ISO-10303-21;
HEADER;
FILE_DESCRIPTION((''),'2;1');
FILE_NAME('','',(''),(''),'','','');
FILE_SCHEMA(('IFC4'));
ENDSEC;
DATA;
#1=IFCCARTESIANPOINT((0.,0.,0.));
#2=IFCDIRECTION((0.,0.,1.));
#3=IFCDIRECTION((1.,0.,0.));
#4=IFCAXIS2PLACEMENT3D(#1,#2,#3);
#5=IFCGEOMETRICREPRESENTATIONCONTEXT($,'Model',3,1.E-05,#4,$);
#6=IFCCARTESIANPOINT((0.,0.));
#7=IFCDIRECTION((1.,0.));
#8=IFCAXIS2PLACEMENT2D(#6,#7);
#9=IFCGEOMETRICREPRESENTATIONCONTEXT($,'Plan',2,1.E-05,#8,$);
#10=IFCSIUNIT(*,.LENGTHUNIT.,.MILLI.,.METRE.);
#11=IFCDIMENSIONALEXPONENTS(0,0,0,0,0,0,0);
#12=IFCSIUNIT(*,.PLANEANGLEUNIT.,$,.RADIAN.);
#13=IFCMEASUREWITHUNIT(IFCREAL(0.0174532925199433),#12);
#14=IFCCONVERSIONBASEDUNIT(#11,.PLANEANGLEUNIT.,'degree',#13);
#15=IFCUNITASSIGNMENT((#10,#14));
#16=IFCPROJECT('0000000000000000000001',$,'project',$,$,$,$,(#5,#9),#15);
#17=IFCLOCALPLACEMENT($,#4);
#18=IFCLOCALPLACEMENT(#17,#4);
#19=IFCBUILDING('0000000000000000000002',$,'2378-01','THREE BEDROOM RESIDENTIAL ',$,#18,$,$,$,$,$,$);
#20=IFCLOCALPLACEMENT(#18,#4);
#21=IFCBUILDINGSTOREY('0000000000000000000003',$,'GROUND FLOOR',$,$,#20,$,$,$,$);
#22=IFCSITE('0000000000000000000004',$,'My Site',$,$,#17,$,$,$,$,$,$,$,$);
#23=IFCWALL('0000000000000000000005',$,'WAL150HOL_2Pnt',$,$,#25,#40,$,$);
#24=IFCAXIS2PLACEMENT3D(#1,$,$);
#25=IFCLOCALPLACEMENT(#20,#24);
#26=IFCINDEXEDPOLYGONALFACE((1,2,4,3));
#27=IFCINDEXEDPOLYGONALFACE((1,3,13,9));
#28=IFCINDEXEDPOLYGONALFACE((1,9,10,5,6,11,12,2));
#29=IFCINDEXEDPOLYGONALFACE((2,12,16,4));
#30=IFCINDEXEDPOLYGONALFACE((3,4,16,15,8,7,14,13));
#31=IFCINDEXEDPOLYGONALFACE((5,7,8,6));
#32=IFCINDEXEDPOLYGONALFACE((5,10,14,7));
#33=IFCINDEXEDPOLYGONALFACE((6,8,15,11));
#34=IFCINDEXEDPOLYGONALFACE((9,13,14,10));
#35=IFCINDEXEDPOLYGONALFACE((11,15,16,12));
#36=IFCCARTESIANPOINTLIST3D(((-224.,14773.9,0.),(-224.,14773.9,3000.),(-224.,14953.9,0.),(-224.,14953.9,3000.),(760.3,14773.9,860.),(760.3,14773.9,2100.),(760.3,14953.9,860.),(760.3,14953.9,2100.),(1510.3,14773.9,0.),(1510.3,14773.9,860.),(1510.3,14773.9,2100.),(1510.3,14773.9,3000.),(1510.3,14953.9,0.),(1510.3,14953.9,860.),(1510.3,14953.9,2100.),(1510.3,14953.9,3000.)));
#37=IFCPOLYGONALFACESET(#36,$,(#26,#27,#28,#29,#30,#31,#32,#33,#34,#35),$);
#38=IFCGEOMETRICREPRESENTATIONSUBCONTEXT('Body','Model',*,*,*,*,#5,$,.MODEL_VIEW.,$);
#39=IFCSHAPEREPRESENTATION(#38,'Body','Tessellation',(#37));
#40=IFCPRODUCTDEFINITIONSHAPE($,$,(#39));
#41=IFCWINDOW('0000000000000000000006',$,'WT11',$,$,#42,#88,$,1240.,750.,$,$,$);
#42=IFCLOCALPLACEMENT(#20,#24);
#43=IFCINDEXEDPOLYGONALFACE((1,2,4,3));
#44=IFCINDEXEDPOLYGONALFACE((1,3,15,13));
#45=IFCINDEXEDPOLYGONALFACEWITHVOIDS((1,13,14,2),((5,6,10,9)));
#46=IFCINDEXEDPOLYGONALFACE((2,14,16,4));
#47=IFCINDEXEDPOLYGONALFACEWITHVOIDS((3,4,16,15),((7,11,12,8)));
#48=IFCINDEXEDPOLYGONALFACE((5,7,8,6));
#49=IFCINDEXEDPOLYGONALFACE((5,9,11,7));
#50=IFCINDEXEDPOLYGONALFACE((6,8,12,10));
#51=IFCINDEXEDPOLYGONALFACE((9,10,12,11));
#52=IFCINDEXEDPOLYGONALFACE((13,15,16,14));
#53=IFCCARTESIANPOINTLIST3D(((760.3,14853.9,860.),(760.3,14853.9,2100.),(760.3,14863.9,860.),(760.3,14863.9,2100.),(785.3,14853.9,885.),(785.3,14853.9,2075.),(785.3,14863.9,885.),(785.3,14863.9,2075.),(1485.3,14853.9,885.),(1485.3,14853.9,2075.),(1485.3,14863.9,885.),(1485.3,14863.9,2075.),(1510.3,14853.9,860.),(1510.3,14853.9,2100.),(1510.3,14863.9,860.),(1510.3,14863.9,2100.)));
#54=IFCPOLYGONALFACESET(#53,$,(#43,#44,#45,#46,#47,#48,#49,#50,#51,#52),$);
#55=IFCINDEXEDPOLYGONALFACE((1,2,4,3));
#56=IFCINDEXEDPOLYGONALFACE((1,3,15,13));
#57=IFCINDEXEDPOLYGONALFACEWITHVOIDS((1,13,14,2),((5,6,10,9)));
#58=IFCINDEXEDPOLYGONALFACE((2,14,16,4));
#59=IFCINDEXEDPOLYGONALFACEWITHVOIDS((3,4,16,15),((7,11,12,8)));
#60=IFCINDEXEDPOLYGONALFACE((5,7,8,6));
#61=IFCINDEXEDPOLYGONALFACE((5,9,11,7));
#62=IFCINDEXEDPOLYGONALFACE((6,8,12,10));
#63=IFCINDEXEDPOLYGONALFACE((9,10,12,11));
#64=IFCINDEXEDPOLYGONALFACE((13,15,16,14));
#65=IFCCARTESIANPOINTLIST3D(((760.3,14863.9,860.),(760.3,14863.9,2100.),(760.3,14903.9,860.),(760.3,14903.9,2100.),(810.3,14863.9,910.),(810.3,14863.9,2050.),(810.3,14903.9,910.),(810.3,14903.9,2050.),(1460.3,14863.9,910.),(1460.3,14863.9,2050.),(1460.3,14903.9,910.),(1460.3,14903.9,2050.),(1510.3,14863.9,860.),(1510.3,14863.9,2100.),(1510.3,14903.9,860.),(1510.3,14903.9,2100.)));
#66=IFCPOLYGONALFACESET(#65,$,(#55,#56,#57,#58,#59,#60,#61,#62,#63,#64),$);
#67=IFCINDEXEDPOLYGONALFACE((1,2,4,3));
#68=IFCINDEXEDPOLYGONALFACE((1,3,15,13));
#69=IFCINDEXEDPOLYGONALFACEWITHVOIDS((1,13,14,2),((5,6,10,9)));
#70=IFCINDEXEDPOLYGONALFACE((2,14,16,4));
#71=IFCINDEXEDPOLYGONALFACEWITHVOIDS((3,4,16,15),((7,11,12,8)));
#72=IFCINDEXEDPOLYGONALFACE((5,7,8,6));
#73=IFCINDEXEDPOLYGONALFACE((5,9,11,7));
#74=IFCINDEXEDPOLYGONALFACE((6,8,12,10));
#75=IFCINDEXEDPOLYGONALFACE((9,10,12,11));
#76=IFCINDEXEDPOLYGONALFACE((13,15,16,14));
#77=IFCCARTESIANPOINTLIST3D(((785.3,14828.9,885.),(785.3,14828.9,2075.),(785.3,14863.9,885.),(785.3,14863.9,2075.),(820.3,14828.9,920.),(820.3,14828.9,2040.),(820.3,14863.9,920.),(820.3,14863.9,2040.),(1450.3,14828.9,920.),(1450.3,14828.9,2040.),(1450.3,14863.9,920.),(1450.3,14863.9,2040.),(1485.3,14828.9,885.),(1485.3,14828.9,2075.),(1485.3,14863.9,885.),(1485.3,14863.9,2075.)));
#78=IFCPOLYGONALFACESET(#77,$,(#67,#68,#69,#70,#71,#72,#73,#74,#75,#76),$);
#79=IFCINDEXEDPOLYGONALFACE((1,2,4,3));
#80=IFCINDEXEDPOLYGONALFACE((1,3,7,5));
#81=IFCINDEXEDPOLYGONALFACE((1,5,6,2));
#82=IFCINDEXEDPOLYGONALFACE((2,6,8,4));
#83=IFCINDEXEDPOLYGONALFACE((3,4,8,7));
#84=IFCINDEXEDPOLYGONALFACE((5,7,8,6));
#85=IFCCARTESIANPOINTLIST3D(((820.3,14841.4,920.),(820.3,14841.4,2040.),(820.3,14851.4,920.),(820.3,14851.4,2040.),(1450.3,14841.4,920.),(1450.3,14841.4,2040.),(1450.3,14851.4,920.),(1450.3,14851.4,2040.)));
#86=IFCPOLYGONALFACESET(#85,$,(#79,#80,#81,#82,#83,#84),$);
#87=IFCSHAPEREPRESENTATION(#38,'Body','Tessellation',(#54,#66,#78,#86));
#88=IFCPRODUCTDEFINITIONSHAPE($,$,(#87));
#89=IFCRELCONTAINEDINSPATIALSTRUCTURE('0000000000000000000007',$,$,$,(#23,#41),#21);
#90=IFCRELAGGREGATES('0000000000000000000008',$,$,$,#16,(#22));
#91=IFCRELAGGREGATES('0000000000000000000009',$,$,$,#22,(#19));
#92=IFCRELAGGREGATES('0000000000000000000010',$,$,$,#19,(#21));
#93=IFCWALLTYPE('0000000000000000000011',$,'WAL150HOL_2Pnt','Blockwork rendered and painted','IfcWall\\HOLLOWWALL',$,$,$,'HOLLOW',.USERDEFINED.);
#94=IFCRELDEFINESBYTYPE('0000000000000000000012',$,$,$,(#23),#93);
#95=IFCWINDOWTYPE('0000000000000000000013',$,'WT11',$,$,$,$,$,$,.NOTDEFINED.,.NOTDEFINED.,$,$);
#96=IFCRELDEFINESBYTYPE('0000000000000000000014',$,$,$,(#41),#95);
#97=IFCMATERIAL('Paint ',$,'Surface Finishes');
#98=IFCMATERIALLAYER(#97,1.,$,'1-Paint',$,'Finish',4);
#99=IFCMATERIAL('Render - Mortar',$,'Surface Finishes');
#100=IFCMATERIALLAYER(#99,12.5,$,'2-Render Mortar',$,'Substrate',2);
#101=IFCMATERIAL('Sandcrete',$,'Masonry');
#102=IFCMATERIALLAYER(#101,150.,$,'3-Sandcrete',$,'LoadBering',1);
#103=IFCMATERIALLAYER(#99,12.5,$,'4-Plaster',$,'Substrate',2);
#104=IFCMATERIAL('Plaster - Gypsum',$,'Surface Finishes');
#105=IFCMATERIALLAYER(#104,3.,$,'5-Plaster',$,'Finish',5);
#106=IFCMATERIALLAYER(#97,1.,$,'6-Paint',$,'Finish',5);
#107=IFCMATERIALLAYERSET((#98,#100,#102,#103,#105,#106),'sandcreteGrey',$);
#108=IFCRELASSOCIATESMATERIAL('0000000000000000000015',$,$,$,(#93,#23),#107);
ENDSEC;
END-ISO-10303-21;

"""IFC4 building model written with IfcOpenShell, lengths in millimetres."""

from ifc_helpers import new_model, entity, si_unit, converted_unit, frame, origin_with_axes, origin_2d_with_axis, place, context, subcontext, project, spatial, line, indexed_curve, outline, extrude, shape, source, transform, mapped, material, layer, layer_set, layer_usage, type_object, type_shapes, element, fill, save


model = new_model("IFC4")

# Units and contexts
model_context = context("Model", 3, precision=1e-05, world=origin_with_axes())
plan_context = context("Plan", 2, precision=1e-05, world=origin_2d_with_axis())
body_context_1 = subcontext(model_context, "Body", "Model", "MODEL_VIEW")
body_context_2 = subcontext(plan_context, "Body", "Plan", "PLAN_VIEW")
ifc_project = project(units=[si_unit("LENGTHUNIT", "METRE", prefix="MILLI"), converted_unit("PLANEANGLEUNIT", "degree", entity("IfcReal", 0.0174532925199433), si_unit("PLANEANGLEUNIT", "RADIAN"), dimensions=[0, 0, 0, 0, 0, 0, 0])], contexts=[model_context, plan_context])

# Site, building, storey
site_placement = place(None, origin_with_axes())
site = spatial("IfcSite", under=ifc_project, at=site_placement, Name="My Site")
building_placement = place(site_placement, origin_with_axes())
building = spatial("IfcBuilding", under=site, at=building_placement, Name="2378-01", Description="THREE BEDROOM RESIDENTIAL ")
storey_placement = place(building_placement, origin_with_axes())
storey = spatial("IfcBuildingStorey", under=building, at=storey_placement, Name="GROUND FLOOR")

# Shared definitions
ifc_material_1 = material(Name="Paint ", Category="Surface Finishes")
ifc_layer_1 = layer(ifc_material_1, 1.0, Name="1-Paint", Category="Finish", Priority=4)
ifc_material_2 = material(Name="Render - Mortar", Category="Surface Finishes")
ifc_layer_2 = layer(ifc_material_2, 12.5, Name="2-Render Mortar", Category="Substrate", Priority=2)
ifc_material_3 = material(Name="Sandcrete", Category="Masonry")
ifc_layer_3 = layer(ifc_material_3, 150.0, Name="3-Sandcrete", Category="LoadBering", Priority=1)
ifc_layer_4 = layer(ifc_material_2, 12.5, Name="4-Plaster", Category="Substrate", Priority=2)
ifc_material_4 = material(Name="Plaster - Gypsum", Category="Surface Finishes")
ifc_layer_5 = layer(ifc_material_4, 3.0, Name="5-Plaster", Category="Finish", Priority=5)
ifc_layer_6 = layer(ifc_material_1, 1.0, Name="6-Paint", Category="Finish", Priority=5)
ifc_layer_set_1 = layer_set([ifc_layer_1, ifc_layer_2, ifc_layer_3, ifc_layer_4, ifc_layer_5, ifc_layer_6], Name="sandcreteGrey")
wall_type_1 = type_object("IfcWallType", Name="WAL150HOL_2Pnt", Description="Blockwork rendered and painted", ApplicableOccurrence="IfcWall\\HOLLOWWALL", ElementType="HOLLOW", PredefinedType="USERDEFINED", material=ifc_layer_set_1)

# Wall, opening, window
ifc_layer_usage_1 = layer_usage(ifc_layer_set_1, "AXIS2", "POSITIVE", 0.0)
wall_1_placement = place(storey_placement, frame((1510.3, 14953.9, 0.0), z_axis=(0.0, 0.0, 1.0), x_axis=(-1.0, 0.0, 0.0)))
wall_1 = element("IfcWall", 1, at=wall_1_placement, inside=storey, type_object=wall_type_1, material=ifc_layer_usage_1, Name="WAL150HOL_2Pnt", context=body_context_1, shape_type="SweptSolid", body=[
    extrude(outline(indexed_curve([(0.0, 0.0), (0.0, 180.0), (1734.3, 180.0), (1734.3, 0.0), (0.0, 0.0)], self_intersect=False)), origin_with_axes(), (0.0, 0.0, 1.0), 3000.0),
])
shared_shape_1 = source(origin_with_axes(), body_context_1, "Body", "SweptSolid", [
    extrude(outline(indexed_curve([(0.0, 0.0), (750.0, 0.0), (750.0, 1240.0), (0.0, 1240.0)], segments=[line(1, 2, 3, 4, 1)])), frame((0.0, -100.0, 0.0), z_axis=(0.0, -1.0, 0.0), x_axis=(1.0, 0.0, 0.0)), (0.0, 0.0, -1.0), 380.0),
])
opening_1_placement = place(wall_1_placement, frame((0.0, 0.0, 860.0), z_axis=(0.0, 0.0, 1.0), x_axis=(1.0, 0.0, 0.0)))
opening_1 = element("IfcOpeningElement", 2, at=opening_1_placement, cuts=wall_1, PredefinedType="OPENING", context=body_context_1, shape_type="MappedRepresentation", body=[
    mapped(shared_shape_1, transform((0.0, 0.0, 0.0), x_axis=(1.0, 0.0, 0.0), y_axis=(0.0, 1.0, 0.0), z_axis=(0.0, 0.0, 1.0), scale=1.0)),
])
window_type_1 = type_object("IfcWindowType", Name="WT11", PartitioningType="NOTDEFINED", PredefinedType="NOTDEFINED")
shared_shape_2 = source(origin_with_axes(), body_context_1, "Body", "SweptSolid", [
    extrude(outline(indexed_curve([(0.0, 0.0), (750.0, 0.0), (750.0, 1240.0), (0.0, 1240.0)], segments=[line(1, 2, 3, 4, 1)]), holes=[indexed_curve([(25.0, 25.0), (725.0, 25.0), (725.0, 1215.0), (25.0, 1215.0)], segments=[line(1, 2, 3, 4, 1)])]), frame((0.0, 90.0, 0.0), z_axis=(0.0, -1.0, 0.0), x_axis=(1.0, 0.0, 0.0)), (0.0, 0.0, -1.0), 10.0),
    extrude(outline(indexed_curve([(0.0, 0.0), (750.0, 0.0), (750.0, 1240.0), (0.0, 1240.0)], segments=[line(1, 2, 3, 4, 1)]), holes=[indexed_curve([(50.0, 50.0), (700.0, 50.0), (700.0, 1190.0), (50.0, 1190.0)], segments=[line(1, 2, 3, 4, 1)])]), frame((0.0, 50.0, 0.0), z_axis=(0.0, -1.0, 0.0), x_axis=(1.0, 0.0, 0.0)), (0.0, 0.0, -1.0), 40.0),
    extrude(outline(indexed_curve([(0.0, 0.0), (700.0, 0.0), (700.0, 1190.0), (0.0, 1190.0)], segments=[line(1, 2, 3, 4, 1)]), holes=[indexed_curve([(35.0, 35.0), (665.0, 35.0), (665.0, 1155.0), (35.0, 1155.0)], segments=[line(1, 2, 3, 4, 1)])]), frame((25.0, 90.0, 25.0), z_axis=(0.0, -1.0, 0.0), x_axis=(1.0, 0.0, 0.0)), (0.0, 0.0, -1.0), 35.0),
    extrude(outline(indexed_curve([(35.0, 35.0), (665.0, 35.0), (665.0, 1155.0), (35.0, 1155.0)], segments=[line(1, 2, 3, 4, 1)])), frame((25.0, 102.5, 25.0), z_axis=(0.0, -1.0, 0.0), x_axis=(1.0, 0.0, 0.0)), (0.0, 0.0, -1.0), 10.0),
])
shared_shape_3 = source(origin_with_axes(), body_context_2, "Body", "Curve2D", [
    entity("IfcIndexedPolyCurve", entity("IfcCartesianPointList2D", [[50.0, 50.0], [700.0, 50.0]])),
    entity("IfcIndexedPolyCurve", entity("IfcCartesianPointList2D", [[0.0, 100.0], [25.0, 100.0], [25.0, 90.0], [50.0, 90.0], [50.0, 50.0], [0.0, 50.0]]), [entity("IfcLineIndex", [1, 2, 3, 4, 5, 6, 1])]),
    entity("IfcIndexedPolyCurve", entity("IfcCartesianPointList2D", [[750.0, 100.0], [725.0, 100.0], [725.0, 90.0], [700.0, 90.0], [700.0, 50.0], [750.0, 50.0]]), [entity("IfcLineIndex", [1, 2, 3, 4, 5, 6, 1])]),
    entity("IfcIndexedPolyCurve", entity("IfcCartesianPointList2D", [[25.0, 90.0], [60.0, 90.0], [60.0, 125.0], [25.0, 125.0]]), [entity("IfcLineIndex", [1, 2, 3, 4, 1])]),
    entity("IfcIndexedPolyCurve", entity("IfcCartesianPointList2D", [[725.0, 90.0], [690.0, 90.0], [690.0, 125.0], [725.0, 125.0]]), [entity("IfcLineIndex", [1, 2, 3, 4, 1])]),
    entity("IfcIndexedPolyCurve", entity("IfcCartesianPointList2D", [[60.0, 90.0], [690.0, 90.0]])),
    entity("IfcIndexedPolyCurve", entity("IfcCartesianPointList2D", [[60.0, 125.0], [690.0, 125.0]])),
    entity("IfcIndexedPolyCurve", entity("IfcCartesianPointList2D", [[60.0, 107.5], [690.0, 107.5]])),
])
type_shapes(window_type_1, [shared_shape_2, shared_shape_3])
window_1_placement = place(opening_1_placement, frame((0.0, 0.0, 0.0), z_axis=(0.0, 0.0, 1.0), x_axis=(1.0, 0.0, 0.0)))
window_1 = element("IfcWindow", 3, at=window_1_placement, inside=storey, type_object=window_type_1, Name="WT11", OverallHeight=1240.0, OverallWidth=750.0, shapes=[
    shape(body_context_1, "Body", "MappedRepresentation", [mapped(shared_shape_2, transform((0.0, 0.0, 0.0), x_axis=(1.0, 0.0, 0.0), y_axis=(0.0, 1.0, 0.0), z_axis=(0.0, 0.0, 1.0), scale=1.0))]),
    shape(body_context_2, "Body", "MappedRepresentation", [mapped(shared_shape_3, transform((0.0, 0.0, 0.0), x_axis=(1.0, 0.0, 0.0), y_axis=(0.0, 1.0, 0.0), z_axis=(0.0, 0.0, 1.0), scale=1.0))]),
])
fill(opening_1, window_1)

save(model, "model.ifc")
